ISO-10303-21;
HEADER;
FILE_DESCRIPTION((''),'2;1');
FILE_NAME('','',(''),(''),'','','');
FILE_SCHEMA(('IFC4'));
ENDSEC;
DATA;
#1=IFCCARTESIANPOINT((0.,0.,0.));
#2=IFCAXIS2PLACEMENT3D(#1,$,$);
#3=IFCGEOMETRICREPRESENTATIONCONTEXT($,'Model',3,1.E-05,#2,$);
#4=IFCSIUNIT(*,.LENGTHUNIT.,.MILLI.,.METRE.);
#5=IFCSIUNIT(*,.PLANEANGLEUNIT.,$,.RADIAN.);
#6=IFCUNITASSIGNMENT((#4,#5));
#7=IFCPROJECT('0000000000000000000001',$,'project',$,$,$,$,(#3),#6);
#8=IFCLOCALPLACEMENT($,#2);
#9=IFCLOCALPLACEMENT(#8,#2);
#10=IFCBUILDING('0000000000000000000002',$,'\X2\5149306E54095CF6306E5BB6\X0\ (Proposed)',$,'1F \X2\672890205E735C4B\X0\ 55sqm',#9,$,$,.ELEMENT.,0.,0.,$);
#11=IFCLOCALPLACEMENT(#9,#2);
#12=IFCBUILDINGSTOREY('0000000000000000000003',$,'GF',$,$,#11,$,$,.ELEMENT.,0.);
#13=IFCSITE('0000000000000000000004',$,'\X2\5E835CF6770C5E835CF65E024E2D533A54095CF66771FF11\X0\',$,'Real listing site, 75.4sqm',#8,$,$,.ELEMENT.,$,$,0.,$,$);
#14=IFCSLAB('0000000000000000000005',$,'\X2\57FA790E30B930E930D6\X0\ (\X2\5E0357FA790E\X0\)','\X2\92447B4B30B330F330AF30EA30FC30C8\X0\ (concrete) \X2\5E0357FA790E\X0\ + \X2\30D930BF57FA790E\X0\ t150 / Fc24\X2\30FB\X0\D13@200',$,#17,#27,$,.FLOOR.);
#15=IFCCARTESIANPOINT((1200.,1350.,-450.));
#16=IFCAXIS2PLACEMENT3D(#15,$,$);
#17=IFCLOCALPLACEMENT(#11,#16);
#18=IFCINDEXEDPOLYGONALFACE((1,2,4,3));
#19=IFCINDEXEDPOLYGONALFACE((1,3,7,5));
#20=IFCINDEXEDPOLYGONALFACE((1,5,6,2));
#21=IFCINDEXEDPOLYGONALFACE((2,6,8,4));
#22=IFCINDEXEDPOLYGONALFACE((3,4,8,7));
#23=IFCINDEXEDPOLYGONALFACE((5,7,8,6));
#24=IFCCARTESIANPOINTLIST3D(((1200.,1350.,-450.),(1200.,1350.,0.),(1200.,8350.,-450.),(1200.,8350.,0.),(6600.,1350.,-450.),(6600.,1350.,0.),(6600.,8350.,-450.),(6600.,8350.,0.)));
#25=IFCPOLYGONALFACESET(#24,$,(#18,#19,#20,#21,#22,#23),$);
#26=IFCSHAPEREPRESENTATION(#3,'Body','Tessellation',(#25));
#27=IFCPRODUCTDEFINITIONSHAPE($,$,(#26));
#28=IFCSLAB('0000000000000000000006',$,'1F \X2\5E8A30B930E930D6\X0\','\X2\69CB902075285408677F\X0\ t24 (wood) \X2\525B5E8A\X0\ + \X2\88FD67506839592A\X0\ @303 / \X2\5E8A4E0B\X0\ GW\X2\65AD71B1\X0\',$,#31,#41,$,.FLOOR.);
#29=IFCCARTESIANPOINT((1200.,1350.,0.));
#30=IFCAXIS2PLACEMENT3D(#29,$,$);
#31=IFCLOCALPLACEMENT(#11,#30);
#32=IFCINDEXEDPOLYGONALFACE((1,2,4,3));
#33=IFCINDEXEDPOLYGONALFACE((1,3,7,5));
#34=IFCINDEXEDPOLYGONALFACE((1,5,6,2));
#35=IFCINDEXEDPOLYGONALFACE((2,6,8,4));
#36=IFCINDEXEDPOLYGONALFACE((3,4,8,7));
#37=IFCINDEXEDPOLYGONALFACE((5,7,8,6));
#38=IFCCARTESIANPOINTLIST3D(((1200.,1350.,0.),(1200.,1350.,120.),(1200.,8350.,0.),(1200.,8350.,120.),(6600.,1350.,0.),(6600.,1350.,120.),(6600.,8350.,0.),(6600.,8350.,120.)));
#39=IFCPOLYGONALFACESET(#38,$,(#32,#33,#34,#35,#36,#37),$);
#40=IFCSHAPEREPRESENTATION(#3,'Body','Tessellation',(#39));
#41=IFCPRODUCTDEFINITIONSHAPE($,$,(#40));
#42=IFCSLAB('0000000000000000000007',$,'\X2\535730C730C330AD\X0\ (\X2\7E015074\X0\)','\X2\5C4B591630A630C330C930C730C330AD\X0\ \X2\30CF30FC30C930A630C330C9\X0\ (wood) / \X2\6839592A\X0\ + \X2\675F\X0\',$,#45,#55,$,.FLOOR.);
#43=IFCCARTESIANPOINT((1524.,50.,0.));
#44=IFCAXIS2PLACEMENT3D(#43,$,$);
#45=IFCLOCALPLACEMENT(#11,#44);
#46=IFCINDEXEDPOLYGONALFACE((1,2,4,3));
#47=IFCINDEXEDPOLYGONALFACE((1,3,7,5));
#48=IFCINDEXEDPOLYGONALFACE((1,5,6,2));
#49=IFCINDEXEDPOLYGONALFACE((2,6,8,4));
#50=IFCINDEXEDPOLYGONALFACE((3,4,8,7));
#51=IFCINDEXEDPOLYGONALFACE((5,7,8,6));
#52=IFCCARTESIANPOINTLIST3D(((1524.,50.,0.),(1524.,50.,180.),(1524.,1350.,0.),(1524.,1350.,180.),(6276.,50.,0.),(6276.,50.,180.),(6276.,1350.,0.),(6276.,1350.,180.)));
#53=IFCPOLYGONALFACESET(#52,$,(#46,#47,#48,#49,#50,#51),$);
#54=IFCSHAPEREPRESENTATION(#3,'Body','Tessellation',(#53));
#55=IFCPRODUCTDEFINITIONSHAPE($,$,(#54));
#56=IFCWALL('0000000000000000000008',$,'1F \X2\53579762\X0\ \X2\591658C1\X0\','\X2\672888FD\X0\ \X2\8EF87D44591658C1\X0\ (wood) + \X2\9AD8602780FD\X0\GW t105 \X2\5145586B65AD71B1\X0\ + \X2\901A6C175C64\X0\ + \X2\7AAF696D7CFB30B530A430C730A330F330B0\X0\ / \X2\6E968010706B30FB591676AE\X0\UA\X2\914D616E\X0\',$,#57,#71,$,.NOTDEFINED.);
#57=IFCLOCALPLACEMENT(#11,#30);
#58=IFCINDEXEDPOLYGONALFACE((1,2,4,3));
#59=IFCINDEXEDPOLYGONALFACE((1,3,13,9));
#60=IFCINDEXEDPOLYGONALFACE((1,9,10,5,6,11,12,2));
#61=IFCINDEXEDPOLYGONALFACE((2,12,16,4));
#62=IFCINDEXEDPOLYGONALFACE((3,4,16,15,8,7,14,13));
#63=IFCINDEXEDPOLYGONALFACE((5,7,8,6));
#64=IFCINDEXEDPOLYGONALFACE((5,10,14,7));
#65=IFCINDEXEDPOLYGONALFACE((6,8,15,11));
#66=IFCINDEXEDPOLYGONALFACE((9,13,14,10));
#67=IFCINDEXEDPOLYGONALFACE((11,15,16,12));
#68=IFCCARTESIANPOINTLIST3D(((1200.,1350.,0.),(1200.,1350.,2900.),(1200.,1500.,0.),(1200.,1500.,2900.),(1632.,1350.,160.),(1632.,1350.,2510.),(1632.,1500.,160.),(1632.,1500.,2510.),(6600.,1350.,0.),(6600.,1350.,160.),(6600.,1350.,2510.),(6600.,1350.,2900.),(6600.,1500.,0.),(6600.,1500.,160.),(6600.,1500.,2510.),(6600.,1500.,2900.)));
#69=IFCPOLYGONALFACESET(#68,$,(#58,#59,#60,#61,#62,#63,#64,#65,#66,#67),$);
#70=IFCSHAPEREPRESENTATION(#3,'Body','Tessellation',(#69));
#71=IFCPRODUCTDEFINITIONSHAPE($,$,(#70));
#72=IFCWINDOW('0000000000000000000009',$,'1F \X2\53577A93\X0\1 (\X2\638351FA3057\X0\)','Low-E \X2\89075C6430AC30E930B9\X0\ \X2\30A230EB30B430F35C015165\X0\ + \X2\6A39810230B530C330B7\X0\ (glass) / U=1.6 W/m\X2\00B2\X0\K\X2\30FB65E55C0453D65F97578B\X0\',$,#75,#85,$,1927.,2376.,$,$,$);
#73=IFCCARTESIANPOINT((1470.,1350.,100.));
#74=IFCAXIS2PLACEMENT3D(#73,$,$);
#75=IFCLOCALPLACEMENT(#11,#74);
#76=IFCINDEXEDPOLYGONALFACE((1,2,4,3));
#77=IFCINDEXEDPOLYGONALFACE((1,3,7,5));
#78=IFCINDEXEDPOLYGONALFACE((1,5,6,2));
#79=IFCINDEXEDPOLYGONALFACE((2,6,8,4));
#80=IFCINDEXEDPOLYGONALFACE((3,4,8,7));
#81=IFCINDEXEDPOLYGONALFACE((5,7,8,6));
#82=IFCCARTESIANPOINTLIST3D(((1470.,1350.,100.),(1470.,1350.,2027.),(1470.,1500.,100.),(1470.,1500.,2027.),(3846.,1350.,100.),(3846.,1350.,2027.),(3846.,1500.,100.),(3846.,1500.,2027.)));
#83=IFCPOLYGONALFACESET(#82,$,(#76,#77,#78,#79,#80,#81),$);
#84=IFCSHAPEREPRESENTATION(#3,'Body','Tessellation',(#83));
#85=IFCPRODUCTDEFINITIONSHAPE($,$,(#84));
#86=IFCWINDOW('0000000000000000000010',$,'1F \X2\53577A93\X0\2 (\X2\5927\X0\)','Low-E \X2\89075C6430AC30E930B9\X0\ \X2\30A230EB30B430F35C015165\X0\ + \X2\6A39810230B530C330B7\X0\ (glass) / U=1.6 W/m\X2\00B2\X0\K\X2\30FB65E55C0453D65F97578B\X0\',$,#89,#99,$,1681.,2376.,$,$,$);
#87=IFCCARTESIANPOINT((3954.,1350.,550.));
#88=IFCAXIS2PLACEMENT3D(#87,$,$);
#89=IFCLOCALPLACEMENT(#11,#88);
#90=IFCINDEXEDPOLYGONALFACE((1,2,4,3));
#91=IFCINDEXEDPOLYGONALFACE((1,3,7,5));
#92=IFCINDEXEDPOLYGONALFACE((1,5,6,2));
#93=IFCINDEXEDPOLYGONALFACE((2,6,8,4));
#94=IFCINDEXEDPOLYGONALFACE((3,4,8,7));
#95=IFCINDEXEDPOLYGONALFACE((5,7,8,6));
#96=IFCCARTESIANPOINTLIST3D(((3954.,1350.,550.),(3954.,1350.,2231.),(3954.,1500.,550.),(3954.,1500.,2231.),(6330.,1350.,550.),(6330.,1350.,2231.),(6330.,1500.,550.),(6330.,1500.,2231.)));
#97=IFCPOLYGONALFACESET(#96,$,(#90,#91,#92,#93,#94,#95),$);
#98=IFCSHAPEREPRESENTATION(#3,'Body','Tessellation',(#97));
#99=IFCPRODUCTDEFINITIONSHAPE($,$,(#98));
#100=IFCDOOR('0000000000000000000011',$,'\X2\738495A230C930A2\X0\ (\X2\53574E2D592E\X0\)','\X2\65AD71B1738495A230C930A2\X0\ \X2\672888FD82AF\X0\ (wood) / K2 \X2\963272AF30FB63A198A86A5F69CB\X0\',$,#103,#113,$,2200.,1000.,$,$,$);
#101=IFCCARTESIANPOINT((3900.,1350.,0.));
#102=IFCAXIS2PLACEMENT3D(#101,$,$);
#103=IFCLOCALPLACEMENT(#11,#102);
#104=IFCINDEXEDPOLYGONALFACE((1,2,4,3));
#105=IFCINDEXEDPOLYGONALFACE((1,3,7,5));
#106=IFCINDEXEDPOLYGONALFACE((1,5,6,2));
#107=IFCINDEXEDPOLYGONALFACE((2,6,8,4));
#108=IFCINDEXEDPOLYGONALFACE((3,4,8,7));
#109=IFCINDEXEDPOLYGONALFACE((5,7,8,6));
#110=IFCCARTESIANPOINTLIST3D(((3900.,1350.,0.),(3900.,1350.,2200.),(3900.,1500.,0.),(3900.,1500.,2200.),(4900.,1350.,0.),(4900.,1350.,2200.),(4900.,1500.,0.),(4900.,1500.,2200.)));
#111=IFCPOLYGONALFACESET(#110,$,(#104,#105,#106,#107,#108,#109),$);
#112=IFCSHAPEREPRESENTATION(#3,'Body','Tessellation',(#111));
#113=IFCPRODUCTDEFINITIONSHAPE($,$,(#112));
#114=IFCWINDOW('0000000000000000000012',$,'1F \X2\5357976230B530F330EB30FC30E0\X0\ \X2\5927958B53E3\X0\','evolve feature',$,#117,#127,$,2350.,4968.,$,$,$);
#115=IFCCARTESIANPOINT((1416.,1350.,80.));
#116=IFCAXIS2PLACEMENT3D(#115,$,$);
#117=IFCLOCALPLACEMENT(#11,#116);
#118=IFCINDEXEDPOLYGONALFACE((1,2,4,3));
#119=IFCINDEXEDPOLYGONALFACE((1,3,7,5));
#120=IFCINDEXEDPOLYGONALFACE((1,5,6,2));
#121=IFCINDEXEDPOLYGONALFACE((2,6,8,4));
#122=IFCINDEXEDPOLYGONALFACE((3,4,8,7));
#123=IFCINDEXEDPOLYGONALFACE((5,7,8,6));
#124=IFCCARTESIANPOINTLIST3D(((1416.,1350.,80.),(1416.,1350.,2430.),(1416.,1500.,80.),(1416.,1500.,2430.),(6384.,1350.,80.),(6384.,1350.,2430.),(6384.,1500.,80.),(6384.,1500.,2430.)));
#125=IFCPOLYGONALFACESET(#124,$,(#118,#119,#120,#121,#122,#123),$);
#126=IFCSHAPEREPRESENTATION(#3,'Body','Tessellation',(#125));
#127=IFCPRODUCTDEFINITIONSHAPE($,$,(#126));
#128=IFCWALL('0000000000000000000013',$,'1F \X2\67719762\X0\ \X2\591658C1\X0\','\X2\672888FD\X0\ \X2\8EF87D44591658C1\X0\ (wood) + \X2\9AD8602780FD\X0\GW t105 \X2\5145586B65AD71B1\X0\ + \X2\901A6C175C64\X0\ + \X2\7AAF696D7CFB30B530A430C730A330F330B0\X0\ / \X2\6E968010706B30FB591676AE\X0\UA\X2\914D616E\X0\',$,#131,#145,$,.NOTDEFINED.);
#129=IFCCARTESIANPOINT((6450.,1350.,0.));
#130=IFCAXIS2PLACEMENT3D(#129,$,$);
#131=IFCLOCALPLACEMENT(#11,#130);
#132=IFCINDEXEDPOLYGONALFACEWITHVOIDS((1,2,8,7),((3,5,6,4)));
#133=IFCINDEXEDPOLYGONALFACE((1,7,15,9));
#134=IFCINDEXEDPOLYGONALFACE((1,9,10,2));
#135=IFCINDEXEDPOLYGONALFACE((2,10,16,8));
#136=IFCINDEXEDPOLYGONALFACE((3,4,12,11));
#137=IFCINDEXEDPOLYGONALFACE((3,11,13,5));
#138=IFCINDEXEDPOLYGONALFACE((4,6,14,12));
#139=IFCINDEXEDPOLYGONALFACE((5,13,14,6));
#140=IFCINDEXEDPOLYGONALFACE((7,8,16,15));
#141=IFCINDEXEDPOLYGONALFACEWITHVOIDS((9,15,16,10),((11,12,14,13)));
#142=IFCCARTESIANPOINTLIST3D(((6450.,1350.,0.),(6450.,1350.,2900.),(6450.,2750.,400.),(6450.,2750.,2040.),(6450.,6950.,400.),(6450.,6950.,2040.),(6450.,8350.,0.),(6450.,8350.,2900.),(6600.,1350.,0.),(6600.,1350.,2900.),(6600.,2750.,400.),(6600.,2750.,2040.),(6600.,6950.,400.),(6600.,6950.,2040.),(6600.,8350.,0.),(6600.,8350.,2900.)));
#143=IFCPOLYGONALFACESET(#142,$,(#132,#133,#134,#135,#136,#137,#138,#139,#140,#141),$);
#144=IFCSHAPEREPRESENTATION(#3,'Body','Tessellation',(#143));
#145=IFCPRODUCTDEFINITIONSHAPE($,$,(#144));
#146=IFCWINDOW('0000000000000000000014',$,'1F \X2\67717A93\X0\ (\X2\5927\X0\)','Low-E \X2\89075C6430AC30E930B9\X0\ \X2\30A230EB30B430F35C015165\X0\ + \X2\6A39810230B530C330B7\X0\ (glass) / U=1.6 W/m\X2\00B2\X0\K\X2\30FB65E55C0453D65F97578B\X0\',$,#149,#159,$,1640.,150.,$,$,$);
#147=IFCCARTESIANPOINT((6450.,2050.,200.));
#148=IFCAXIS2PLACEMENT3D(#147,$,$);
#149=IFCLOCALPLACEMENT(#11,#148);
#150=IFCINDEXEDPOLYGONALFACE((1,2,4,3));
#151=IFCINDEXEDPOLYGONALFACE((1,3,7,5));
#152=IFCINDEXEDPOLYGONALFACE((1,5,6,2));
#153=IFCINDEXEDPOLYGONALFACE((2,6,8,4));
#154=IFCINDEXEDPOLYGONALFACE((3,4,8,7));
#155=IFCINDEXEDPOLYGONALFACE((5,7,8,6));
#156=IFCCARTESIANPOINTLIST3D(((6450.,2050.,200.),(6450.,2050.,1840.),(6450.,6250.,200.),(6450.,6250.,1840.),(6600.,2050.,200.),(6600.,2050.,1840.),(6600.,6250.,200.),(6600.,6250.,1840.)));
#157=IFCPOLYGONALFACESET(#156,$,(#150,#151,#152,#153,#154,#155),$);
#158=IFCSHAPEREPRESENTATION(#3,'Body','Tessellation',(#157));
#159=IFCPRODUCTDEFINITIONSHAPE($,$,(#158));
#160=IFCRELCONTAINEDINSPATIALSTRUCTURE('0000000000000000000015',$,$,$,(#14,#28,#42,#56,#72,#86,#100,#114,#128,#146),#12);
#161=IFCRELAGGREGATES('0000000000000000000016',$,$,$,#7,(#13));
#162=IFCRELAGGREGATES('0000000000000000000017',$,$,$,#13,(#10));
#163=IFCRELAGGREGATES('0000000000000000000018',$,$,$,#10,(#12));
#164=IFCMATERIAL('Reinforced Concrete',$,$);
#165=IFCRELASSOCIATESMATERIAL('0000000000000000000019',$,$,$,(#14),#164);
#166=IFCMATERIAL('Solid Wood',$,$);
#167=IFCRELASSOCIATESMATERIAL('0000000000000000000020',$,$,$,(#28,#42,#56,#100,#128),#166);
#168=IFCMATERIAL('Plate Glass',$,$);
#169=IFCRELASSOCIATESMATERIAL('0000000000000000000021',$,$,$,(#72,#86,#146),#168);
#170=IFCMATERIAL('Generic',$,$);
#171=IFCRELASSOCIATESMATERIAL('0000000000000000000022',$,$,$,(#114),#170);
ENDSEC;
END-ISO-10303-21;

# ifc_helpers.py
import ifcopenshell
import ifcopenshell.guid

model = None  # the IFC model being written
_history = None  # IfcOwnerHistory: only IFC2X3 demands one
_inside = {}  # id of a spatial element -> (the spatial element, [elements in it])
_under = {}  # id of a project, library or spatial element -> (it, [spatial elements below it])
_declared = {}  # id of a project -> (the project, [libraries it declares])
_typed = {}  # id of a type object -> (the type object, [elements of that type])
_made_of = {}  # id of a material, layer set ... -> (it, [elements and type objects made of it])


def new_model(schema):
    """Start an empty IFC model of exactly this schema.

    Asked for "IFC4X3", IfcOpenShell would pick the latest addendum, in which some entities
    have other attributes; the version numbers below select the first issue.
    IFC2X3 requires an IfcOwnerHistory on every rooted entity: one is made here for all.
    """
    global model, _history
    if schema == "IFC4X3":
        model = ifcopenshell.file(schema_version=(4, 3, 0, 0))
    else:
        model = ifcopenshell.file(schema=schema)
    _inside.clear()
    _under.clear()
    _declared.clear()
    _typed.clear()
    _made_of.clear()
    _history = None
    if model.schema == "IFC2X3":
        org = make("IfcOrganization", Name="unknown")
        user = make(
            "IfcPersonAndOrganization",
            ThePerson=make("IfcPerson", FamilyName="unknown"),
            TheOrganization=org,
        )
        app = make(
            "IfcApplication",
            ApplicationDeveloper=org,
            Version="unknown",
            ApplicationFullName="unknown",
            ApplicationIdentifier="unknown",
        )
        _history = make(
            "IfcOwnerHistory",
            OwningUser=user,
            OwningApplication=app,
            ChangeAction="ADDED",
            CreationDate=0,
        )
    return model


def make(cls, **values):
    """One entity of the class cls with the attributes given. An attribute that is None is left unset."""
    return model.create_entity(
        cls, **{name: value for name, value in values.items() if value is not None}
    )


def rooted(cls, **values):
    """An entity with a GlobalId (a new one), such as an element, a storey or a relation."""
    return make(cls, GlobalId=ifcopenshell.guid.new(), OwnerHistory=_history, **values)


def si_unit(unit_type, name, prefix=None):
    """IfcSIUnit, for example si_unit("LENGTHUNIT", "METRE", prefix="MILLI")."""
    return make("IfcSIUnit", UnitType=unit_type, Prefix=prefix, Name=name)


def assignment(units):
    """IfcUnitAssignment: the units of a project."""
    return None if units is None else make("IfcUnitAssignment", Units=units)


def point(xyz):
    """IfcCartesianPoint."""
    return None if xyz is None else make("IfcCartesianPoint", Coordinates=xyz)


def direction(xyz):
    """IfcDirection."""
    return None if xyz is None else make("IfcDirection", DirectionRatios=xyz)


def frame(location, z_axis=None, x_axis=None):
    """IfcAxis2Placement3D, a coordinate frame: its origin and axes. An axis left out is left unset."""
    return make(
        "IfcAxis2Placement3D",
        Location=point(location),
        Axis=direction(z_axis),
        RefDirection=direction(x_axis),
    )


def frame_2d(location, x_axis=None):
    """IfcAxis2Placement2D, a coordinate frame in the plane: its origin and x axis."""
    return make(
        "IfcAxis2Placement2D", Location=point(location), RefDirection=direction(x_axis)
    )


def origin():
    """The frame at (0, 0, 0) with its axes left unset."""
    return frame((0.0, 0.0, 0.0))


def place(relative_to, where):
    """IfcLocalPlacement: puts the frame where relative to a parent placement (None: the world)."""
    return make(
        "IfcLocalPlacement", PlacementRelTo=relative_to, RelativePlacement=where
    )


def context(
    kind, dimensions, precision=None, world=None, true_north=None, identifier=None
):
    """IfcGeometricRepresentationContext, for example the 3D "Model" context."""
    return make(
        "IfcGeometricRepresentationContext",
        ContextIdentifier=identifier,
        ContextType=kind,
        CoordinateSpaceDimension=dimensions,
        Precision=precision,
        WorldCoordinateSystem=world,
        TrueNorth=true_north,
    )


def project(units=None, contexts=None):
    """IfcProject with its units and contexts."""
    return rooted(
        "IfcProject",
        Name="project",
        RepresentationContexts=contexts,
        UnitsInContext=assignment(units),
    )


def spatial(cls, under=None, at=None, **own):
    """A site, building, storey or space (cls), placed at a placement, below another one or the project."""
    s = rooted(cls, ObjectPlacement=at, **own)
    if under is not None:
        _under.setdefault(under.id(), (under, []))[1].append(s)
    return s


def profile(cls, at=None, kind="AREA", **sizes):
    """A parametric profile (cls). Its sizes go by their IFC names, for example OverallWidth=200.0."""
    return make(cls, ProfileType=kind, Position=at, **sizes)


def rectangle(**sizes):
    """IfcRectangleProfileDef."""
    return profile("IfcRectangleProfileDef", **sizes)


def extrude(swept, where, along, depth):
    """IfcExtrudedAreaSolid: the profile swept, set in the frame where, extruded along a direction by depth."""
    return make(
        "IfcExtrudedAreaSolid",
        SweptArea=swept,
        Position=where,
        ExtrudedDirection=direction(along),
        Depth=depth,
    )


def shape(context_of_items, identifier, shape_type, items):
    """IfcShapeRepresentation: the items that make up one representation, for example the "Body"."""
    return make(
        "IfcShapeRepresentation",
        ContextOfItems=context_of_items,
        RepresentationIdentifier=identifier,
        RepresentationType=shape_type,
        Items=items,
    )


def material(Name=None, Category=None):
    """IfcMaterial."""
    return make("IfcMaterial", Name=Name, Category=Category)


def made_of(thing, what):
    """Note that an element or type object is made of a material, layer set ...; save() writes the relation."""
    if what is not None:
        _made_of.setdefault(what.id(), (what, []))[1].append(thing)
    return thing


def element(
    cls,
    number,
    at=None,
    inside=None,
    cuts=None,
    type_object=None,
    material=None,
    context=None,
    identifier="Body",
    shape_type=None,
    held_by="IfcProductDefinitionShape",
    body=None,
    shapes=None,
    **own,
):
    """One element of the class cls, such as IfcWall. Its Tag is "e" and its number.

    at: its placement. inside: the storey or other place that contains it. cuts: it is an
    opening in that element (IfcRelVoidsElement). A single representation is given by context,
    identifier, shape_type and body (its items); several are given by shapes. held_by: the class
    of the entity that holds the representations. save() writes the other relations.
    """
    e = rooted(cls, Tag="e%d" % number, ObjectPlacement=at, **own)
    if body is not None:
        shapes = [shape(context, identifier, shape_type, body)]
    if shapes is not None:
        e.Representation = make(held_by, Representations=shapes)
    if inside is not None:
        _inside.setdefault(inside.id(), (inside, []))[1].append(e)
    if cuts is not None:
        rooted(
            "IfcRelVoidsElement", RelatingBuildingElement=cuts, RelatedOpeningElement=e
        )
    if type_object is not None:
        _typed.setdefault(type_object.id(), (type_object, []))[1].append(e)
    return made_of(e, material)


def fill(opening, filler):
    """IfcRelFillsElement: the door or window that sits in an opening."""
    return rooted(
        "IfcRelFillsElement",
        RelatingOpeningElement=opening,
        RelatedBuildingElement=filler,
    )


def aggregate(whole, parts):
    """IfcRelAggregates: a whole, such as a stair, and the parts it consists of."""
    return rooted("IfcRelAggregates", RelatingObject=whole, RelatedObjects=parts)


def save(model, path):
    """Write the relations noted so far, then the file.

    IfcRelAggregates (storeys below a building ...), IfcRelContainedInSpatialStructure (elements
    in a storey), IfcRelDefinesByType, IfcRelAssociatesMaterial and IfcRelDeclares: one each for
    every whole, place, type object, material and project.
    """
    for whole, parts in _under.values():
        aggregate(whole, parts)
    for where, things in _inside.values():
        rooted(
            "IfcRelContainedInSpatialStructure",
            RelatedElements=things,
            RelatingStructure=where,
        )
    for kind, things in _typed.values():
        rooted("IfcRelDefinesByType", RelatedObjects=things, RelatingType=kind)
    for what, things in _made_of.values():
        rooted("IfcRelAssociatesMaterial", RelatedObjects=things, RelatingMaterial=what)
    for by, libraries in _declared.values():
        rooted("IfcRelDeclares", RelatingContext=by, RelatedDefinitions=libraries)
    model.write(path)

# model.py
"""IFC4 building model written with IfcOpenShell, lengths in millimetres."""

from ifc_helpers import new_model, si_unit, frame, frame_2d, origin, place, context, project, spatial, rectangle, extrude, material, element, fill, save


model = new_model("IFC4")

# Units and contexts
model_context = context("Model", 3, precision=1e-05, world=origin())
ifc_project = project(units=[si_unit("LENGTHUNIT", "METRE", prefix="MILLI"), si_unit("PLANEANGLEUNIT", "RADIAN")], contexts=[model_context])

# Site, building, storey
site_placement = place(None, origin())
site = spatial("IfcSite", under=ifc_project, at=site_placement, Name="広島県広島市中区吉島東１", ObjectType="Real listing site, 75.4sqm", CompositionType="ELEMENT", RefElevation=0.0)
building_placement = place(site_placement, origin())
building = spatial("IfcBuilding", under=site, at=building_placement, Name="光の吉島の家 (Proposed)", ObjectType="1F 木造平屋 55sqm", CompositionType="ELEMENT", ElevationOfRefHeight=0.0, ElevationOfTerrain=0.0)
storey_placement = place(building_placement, origin())
storey = spatial("IfcBuildingStorey", under=building, at=storey_placement, Name="GF", CompositionType="ELEMENT", Elevation=0.0)

# Slabs
ifc_material_1 = material(Name="Reinforced Concrete")
slab_1_placement = place(storey_placement, frame((1200.0, 1350.0, -450.0)))
element("IfcSlab", 1, at=slab_1_placement, inside=storey, material=ifc_material_1, Name="基礎スラブ (布基礎)", Description="鉄筋コンクリート (concrete) 布基礎 + ベタ基礎 t150 / Fc24・D13@200", PredefinedType="FLOOR", context=model_context, shape_type="SweptSolid", body=[
    extrude(rectangle(XDim=5400.0, YDim=7000.0, at=frame_2d((2700.0, 3500.0))), frame((1200.0, 1350.0, -450.0)), (0.0, 0.0, 1.0), 450.0),
])
ifc_material_2 = material(Name="Solid Wood")
slab_2_placement = place(storey_placement, frame((1200.0, 1350.0, 0.0)))
element("IfcSlab", 2, at=slab_2_placement, inside=storey, material=ifc_material_2, Name="1F 床スラブ", Description="構造用合板 t24 (wood) 剛床 + 製材根太 @303 / 床下 GW断熱", PredefinedType="FLOOR", context=model_context, shape_type="SweptSolid", body=[
    extrude(rectangle(XDim=5400.0, YDim=7000.0, at=frame_2d((2700.0, 3500.0))), frame((1200.0, 1350.0, 0.0)), (0.0, 0.0, 1.0), 120.0),
])
slab_3_placement = place(storey_placement, frame((1524.0, 50.0, 0.0)))
element("IfcSlab", 3, at=slab_3_placement, inside=storey, material=ifc_material_2, Name="南デッキ (縁側)", Description="屋外ウッドデッキ ハードウッド (wood) / 根太 + 束", PredefinedType="FLOOR", context=model_context, shape_type="SweptSolid", body=[
    extrude(rectangle(XDim=4752.0, YDim=1300.0, at=frame_2d((2376.0, 650.0))), frame((1524.0, 50.0, 0.0)), (0.0, 0.0, 1.0), 180.0),
])
ifc_material_3 = material(Name="Generic")

# Wall, openings, windows, door
wall_1_placement = place(storey_placement, frame((1200.0, 1350.0, 0.0)))
wall_1 = element("IfcWall", 4, at=wall_1_placement, inside=storey, material=ifc_material_2, Name="1F 南面 外壁", Description="木製 軸組外壁 (wood) + 高性能GW t105 充填断熱 + 通気層 + 窯業系サイディング / 準耐火・外皮UA配慮", PredefinedType="NOTDEFINED", context=model_context, shape_type="SweptSolid", body=[
    extrude(rectangle(XDim=5400.0, YDim=150.0, at=frame_2d((2700.0, 75.0))), frame((1200.0, 1350.0, 0.0)), (0.0, 0.0, 1.0), 2900.0),
])
opening_1_placement = place(storey_placement, frame((1470.0, 1350.0, 100.0)))
opening_1 = element("IfcOpeningElement", 5, at=opening_1_placement, cuts=wall_1, PredefinedType="NOTDEFINED", context=model_context, shape_type="SweptSolid", body=[
    extrude(rectangle(XDim=2376.0, YDim=150.0, at=frame_2d((1188.0, 75.0))), frame((1470.0, 1350.0, 100.0)), (0.0, 0.0, 1.0), 1927.0),
])
opening_2_placement = place(storey_placement, frame((3954.0, 1350.0, 550.0)))
opening_2 = element("IfcOpeningElement", 6, at=opening_2_placement, cuts=wall_1, PredefinedType="NOTDEFINED", context=model_context, shape_type="SweptSolid", body=[
    extrude(rectangle(XDim=2376.0, YDim=150.0, at=frame_2d((1188.0, 75.0))), frame((3954.0, 1350.0, 550.0)), (0.0, 0.0, 1.0), 1681.0),
])
opening_3_placement = place(storey_placement, frame((3900.0, 1350.0, 0.0)))
opening_3 = element("IfcOpeningElement", 7, at=opening_3_placement, cuts=wall_1, PredefinedType="NOTDEFINED", context=model_context, shape_type="SweptSolid", body=[
    extrude(rectangle(XDim=1000.0, YDim=150.0, at=frame_2d((500.0, 75.0))), frame((3900.0, 1350.0, 0.0)), (0.0, 0.0, 1.0), 2200.0),
])
opening_4_placement = place(storey_placement, frame((1416.0, 1350.0, 80.0)))
opening_4 = element("IfcOpeningElement", 8, at=opening_4_placement, cuts=wall_1, PredefinedType="NOTDEFINED", context=model_context, shape_type="SweptSolid", body=[
    extrude(rectangle(XDim=4968.0, YDim=150.0, at=frame_2d((2484.0, 75.0))), frame((1416.0, 1350.0, 80.0)), (0.0, 0.0, 1.0), 2350.0),
])
ifc_material_4 = material(Name="Plate Glass")
window_1_placement = place(storey_placement, frame((1470.0, 1350.0, 100.0)))
window_1 = element("IfcWindow", 9, at=window_1_placement, inside=storey, material=ifc_material_4, Name="1F 南窓1 (掃出し)", Description="Low-E 複層ガラス アルゴン封入 + 樹脂サッシ (glass) / U=1.6 W/m²K・日射取得型", OverallHeight=1927.0, OverallWidth=2376.0, context=model_context, shape_type="SweptSolid", body=[
    extrude(rectangle(XDim=2376.0, YDim=150.0, at=frame_2d((1188.0, 75.0))), frame((1470.0, 1350.0, 100.0)), (0.0, 0.0, 1.0), 1927.0),
])
fill(opening_1, window_1)
window_2_placement = place(storey_placement, frame((3954.0, 1350.0, 550.0)))
window_2 = element("IfcWindow", 10, at=window_2_placement, inside=storey, material=ifc_material_4, Name="1F 南窓2 (大)", Description="Low-E 複層ガラス アルゴン封入 + 樹脂サッシ (glass) / U=1.6 W/m²K・日射取得型", OverallHeight=1681.0, OverallWidth=2376.0, context=model_context, shape_type="SweptSolid", body=[
    extrude(rectangle(XDim=2376.0, YDim=150.0, at=frame_2d((1188.0, 75.0))), frame((3954.0, 1350.0, 550.0)), (0.0, 0.0, 1.0), 1681.0),
])
fill(opening_2, window_2)
door_placement = place(storey_placement, frame((3900.0, 1350.0, 0.0)))
door = element("IfcDoor", 11, at=door_placement, inside=storey, material=ifc_material_2, Name="玄関ドア (南中央)", Description="断熱玄関ドア 木製芯 (wood) / K2 防犯・採風機構", OverallHeight=2200.0, OverallWidth=1000.0, context=model_context, shape_type="SweptSolid", body=[
    extrude(rectangle(XDim=1000.0, YDim=150.0, at=frame_2d((500.0, 75.0))), frame((3900.0, 1350.0, 0.0)), (0.0, 0.0, 1.0), 2200.0),
])
fill(opening_3, door)
window_3_placement = place(storey_placement, frame((1416.0, 1350.0, 80.0)))
window_3 = element("IfcWindow", 12, at=window_3_placement, inside=storey, material=ifc_material_3, Name="1F 南面サンルーム 大開口", Description="evolve feature", OverallHeight=2350.0, OverallWidth=4968.0, context=model_context, shape_type="SweptSolid", body=[
    extrude(rectangle(XDim=4968.0, YDim=150.0, at=frame_2d((2484.0, 75.0))), frame((1416.0, 1350.0, 80.0)), (0.0, 0.0, 1.0), 2350.0),
])
fill(opening_4, window_3)

# Wall, opening, window
wall_2_placement = place(storey_placement, frame((6450.0, 1350.0, 0.0)))
wall_2 = element("IfcWall", 13, at=wall_2_placement, inside=storey, material=ifc_material_2, Name="1F 東面 外壁", Description="木製 軸組外壁 (wood) + 高性能GW t105 充填断熱 + 通気層 + 窯業系サイディング / 準耐火・外皮UA配慮", PredefinedType="NOTDEFINED", context=model_context, shape_type="SweptSolid", body=[
    extrude(rectangle(XDim=150.0, YDim=7000.0, at=frame_2d((75.0, 3500.0))), frame((6450.0, 1350.0, 0.0)), (0.0, 0.0, 1.0), 2900.0),
])
opening_5_placement = place(storey_placement, frame((6450.0, 2050.0, 200.0)))
opening_5 = element("IfcOpeningElement", 14, at=opening_5_placement, cuts=wall_2, PredefinedType="NOTDEFINED", context=model_context, shape_type="SweptSolid", body=[
    extrude(rectangle(XDim=150.0, YDim=4200.0, at=frame_2d((75.0, 2100.0))), frame((6450.0, 2050.0, 200.0)), (0.0, 0.0, 1.0), 1640.0),
])
window_4_placement = place(storey_placement, frame((6450.0, 2050.0, 200.0)))
window_4 = element("IfcWindow", 15, at=window_4_placement, inside=storey, material=ifc_material_4, Name="1F 東窓 (大)", Description="Low-E 複層ガラス アルゴン封入 + 樹脂サッシ (glass) / U=1.6 W/m²K・日射取得型", OverallHeight=1640.0, OverallWidth=150.0, context=model_context, shape_type="SweptSolid", body=[
    extrude(rectangle(XDim=150.0, YDim=4200.0, at=frame_2d((75.0, 2100.0))), frame((6450.0, 2050.0, 200.0)), (0.0, 0.0, 1.0), 1640.0),
])
fill(opening_5, window_4)

save(model, "model.ifc")
